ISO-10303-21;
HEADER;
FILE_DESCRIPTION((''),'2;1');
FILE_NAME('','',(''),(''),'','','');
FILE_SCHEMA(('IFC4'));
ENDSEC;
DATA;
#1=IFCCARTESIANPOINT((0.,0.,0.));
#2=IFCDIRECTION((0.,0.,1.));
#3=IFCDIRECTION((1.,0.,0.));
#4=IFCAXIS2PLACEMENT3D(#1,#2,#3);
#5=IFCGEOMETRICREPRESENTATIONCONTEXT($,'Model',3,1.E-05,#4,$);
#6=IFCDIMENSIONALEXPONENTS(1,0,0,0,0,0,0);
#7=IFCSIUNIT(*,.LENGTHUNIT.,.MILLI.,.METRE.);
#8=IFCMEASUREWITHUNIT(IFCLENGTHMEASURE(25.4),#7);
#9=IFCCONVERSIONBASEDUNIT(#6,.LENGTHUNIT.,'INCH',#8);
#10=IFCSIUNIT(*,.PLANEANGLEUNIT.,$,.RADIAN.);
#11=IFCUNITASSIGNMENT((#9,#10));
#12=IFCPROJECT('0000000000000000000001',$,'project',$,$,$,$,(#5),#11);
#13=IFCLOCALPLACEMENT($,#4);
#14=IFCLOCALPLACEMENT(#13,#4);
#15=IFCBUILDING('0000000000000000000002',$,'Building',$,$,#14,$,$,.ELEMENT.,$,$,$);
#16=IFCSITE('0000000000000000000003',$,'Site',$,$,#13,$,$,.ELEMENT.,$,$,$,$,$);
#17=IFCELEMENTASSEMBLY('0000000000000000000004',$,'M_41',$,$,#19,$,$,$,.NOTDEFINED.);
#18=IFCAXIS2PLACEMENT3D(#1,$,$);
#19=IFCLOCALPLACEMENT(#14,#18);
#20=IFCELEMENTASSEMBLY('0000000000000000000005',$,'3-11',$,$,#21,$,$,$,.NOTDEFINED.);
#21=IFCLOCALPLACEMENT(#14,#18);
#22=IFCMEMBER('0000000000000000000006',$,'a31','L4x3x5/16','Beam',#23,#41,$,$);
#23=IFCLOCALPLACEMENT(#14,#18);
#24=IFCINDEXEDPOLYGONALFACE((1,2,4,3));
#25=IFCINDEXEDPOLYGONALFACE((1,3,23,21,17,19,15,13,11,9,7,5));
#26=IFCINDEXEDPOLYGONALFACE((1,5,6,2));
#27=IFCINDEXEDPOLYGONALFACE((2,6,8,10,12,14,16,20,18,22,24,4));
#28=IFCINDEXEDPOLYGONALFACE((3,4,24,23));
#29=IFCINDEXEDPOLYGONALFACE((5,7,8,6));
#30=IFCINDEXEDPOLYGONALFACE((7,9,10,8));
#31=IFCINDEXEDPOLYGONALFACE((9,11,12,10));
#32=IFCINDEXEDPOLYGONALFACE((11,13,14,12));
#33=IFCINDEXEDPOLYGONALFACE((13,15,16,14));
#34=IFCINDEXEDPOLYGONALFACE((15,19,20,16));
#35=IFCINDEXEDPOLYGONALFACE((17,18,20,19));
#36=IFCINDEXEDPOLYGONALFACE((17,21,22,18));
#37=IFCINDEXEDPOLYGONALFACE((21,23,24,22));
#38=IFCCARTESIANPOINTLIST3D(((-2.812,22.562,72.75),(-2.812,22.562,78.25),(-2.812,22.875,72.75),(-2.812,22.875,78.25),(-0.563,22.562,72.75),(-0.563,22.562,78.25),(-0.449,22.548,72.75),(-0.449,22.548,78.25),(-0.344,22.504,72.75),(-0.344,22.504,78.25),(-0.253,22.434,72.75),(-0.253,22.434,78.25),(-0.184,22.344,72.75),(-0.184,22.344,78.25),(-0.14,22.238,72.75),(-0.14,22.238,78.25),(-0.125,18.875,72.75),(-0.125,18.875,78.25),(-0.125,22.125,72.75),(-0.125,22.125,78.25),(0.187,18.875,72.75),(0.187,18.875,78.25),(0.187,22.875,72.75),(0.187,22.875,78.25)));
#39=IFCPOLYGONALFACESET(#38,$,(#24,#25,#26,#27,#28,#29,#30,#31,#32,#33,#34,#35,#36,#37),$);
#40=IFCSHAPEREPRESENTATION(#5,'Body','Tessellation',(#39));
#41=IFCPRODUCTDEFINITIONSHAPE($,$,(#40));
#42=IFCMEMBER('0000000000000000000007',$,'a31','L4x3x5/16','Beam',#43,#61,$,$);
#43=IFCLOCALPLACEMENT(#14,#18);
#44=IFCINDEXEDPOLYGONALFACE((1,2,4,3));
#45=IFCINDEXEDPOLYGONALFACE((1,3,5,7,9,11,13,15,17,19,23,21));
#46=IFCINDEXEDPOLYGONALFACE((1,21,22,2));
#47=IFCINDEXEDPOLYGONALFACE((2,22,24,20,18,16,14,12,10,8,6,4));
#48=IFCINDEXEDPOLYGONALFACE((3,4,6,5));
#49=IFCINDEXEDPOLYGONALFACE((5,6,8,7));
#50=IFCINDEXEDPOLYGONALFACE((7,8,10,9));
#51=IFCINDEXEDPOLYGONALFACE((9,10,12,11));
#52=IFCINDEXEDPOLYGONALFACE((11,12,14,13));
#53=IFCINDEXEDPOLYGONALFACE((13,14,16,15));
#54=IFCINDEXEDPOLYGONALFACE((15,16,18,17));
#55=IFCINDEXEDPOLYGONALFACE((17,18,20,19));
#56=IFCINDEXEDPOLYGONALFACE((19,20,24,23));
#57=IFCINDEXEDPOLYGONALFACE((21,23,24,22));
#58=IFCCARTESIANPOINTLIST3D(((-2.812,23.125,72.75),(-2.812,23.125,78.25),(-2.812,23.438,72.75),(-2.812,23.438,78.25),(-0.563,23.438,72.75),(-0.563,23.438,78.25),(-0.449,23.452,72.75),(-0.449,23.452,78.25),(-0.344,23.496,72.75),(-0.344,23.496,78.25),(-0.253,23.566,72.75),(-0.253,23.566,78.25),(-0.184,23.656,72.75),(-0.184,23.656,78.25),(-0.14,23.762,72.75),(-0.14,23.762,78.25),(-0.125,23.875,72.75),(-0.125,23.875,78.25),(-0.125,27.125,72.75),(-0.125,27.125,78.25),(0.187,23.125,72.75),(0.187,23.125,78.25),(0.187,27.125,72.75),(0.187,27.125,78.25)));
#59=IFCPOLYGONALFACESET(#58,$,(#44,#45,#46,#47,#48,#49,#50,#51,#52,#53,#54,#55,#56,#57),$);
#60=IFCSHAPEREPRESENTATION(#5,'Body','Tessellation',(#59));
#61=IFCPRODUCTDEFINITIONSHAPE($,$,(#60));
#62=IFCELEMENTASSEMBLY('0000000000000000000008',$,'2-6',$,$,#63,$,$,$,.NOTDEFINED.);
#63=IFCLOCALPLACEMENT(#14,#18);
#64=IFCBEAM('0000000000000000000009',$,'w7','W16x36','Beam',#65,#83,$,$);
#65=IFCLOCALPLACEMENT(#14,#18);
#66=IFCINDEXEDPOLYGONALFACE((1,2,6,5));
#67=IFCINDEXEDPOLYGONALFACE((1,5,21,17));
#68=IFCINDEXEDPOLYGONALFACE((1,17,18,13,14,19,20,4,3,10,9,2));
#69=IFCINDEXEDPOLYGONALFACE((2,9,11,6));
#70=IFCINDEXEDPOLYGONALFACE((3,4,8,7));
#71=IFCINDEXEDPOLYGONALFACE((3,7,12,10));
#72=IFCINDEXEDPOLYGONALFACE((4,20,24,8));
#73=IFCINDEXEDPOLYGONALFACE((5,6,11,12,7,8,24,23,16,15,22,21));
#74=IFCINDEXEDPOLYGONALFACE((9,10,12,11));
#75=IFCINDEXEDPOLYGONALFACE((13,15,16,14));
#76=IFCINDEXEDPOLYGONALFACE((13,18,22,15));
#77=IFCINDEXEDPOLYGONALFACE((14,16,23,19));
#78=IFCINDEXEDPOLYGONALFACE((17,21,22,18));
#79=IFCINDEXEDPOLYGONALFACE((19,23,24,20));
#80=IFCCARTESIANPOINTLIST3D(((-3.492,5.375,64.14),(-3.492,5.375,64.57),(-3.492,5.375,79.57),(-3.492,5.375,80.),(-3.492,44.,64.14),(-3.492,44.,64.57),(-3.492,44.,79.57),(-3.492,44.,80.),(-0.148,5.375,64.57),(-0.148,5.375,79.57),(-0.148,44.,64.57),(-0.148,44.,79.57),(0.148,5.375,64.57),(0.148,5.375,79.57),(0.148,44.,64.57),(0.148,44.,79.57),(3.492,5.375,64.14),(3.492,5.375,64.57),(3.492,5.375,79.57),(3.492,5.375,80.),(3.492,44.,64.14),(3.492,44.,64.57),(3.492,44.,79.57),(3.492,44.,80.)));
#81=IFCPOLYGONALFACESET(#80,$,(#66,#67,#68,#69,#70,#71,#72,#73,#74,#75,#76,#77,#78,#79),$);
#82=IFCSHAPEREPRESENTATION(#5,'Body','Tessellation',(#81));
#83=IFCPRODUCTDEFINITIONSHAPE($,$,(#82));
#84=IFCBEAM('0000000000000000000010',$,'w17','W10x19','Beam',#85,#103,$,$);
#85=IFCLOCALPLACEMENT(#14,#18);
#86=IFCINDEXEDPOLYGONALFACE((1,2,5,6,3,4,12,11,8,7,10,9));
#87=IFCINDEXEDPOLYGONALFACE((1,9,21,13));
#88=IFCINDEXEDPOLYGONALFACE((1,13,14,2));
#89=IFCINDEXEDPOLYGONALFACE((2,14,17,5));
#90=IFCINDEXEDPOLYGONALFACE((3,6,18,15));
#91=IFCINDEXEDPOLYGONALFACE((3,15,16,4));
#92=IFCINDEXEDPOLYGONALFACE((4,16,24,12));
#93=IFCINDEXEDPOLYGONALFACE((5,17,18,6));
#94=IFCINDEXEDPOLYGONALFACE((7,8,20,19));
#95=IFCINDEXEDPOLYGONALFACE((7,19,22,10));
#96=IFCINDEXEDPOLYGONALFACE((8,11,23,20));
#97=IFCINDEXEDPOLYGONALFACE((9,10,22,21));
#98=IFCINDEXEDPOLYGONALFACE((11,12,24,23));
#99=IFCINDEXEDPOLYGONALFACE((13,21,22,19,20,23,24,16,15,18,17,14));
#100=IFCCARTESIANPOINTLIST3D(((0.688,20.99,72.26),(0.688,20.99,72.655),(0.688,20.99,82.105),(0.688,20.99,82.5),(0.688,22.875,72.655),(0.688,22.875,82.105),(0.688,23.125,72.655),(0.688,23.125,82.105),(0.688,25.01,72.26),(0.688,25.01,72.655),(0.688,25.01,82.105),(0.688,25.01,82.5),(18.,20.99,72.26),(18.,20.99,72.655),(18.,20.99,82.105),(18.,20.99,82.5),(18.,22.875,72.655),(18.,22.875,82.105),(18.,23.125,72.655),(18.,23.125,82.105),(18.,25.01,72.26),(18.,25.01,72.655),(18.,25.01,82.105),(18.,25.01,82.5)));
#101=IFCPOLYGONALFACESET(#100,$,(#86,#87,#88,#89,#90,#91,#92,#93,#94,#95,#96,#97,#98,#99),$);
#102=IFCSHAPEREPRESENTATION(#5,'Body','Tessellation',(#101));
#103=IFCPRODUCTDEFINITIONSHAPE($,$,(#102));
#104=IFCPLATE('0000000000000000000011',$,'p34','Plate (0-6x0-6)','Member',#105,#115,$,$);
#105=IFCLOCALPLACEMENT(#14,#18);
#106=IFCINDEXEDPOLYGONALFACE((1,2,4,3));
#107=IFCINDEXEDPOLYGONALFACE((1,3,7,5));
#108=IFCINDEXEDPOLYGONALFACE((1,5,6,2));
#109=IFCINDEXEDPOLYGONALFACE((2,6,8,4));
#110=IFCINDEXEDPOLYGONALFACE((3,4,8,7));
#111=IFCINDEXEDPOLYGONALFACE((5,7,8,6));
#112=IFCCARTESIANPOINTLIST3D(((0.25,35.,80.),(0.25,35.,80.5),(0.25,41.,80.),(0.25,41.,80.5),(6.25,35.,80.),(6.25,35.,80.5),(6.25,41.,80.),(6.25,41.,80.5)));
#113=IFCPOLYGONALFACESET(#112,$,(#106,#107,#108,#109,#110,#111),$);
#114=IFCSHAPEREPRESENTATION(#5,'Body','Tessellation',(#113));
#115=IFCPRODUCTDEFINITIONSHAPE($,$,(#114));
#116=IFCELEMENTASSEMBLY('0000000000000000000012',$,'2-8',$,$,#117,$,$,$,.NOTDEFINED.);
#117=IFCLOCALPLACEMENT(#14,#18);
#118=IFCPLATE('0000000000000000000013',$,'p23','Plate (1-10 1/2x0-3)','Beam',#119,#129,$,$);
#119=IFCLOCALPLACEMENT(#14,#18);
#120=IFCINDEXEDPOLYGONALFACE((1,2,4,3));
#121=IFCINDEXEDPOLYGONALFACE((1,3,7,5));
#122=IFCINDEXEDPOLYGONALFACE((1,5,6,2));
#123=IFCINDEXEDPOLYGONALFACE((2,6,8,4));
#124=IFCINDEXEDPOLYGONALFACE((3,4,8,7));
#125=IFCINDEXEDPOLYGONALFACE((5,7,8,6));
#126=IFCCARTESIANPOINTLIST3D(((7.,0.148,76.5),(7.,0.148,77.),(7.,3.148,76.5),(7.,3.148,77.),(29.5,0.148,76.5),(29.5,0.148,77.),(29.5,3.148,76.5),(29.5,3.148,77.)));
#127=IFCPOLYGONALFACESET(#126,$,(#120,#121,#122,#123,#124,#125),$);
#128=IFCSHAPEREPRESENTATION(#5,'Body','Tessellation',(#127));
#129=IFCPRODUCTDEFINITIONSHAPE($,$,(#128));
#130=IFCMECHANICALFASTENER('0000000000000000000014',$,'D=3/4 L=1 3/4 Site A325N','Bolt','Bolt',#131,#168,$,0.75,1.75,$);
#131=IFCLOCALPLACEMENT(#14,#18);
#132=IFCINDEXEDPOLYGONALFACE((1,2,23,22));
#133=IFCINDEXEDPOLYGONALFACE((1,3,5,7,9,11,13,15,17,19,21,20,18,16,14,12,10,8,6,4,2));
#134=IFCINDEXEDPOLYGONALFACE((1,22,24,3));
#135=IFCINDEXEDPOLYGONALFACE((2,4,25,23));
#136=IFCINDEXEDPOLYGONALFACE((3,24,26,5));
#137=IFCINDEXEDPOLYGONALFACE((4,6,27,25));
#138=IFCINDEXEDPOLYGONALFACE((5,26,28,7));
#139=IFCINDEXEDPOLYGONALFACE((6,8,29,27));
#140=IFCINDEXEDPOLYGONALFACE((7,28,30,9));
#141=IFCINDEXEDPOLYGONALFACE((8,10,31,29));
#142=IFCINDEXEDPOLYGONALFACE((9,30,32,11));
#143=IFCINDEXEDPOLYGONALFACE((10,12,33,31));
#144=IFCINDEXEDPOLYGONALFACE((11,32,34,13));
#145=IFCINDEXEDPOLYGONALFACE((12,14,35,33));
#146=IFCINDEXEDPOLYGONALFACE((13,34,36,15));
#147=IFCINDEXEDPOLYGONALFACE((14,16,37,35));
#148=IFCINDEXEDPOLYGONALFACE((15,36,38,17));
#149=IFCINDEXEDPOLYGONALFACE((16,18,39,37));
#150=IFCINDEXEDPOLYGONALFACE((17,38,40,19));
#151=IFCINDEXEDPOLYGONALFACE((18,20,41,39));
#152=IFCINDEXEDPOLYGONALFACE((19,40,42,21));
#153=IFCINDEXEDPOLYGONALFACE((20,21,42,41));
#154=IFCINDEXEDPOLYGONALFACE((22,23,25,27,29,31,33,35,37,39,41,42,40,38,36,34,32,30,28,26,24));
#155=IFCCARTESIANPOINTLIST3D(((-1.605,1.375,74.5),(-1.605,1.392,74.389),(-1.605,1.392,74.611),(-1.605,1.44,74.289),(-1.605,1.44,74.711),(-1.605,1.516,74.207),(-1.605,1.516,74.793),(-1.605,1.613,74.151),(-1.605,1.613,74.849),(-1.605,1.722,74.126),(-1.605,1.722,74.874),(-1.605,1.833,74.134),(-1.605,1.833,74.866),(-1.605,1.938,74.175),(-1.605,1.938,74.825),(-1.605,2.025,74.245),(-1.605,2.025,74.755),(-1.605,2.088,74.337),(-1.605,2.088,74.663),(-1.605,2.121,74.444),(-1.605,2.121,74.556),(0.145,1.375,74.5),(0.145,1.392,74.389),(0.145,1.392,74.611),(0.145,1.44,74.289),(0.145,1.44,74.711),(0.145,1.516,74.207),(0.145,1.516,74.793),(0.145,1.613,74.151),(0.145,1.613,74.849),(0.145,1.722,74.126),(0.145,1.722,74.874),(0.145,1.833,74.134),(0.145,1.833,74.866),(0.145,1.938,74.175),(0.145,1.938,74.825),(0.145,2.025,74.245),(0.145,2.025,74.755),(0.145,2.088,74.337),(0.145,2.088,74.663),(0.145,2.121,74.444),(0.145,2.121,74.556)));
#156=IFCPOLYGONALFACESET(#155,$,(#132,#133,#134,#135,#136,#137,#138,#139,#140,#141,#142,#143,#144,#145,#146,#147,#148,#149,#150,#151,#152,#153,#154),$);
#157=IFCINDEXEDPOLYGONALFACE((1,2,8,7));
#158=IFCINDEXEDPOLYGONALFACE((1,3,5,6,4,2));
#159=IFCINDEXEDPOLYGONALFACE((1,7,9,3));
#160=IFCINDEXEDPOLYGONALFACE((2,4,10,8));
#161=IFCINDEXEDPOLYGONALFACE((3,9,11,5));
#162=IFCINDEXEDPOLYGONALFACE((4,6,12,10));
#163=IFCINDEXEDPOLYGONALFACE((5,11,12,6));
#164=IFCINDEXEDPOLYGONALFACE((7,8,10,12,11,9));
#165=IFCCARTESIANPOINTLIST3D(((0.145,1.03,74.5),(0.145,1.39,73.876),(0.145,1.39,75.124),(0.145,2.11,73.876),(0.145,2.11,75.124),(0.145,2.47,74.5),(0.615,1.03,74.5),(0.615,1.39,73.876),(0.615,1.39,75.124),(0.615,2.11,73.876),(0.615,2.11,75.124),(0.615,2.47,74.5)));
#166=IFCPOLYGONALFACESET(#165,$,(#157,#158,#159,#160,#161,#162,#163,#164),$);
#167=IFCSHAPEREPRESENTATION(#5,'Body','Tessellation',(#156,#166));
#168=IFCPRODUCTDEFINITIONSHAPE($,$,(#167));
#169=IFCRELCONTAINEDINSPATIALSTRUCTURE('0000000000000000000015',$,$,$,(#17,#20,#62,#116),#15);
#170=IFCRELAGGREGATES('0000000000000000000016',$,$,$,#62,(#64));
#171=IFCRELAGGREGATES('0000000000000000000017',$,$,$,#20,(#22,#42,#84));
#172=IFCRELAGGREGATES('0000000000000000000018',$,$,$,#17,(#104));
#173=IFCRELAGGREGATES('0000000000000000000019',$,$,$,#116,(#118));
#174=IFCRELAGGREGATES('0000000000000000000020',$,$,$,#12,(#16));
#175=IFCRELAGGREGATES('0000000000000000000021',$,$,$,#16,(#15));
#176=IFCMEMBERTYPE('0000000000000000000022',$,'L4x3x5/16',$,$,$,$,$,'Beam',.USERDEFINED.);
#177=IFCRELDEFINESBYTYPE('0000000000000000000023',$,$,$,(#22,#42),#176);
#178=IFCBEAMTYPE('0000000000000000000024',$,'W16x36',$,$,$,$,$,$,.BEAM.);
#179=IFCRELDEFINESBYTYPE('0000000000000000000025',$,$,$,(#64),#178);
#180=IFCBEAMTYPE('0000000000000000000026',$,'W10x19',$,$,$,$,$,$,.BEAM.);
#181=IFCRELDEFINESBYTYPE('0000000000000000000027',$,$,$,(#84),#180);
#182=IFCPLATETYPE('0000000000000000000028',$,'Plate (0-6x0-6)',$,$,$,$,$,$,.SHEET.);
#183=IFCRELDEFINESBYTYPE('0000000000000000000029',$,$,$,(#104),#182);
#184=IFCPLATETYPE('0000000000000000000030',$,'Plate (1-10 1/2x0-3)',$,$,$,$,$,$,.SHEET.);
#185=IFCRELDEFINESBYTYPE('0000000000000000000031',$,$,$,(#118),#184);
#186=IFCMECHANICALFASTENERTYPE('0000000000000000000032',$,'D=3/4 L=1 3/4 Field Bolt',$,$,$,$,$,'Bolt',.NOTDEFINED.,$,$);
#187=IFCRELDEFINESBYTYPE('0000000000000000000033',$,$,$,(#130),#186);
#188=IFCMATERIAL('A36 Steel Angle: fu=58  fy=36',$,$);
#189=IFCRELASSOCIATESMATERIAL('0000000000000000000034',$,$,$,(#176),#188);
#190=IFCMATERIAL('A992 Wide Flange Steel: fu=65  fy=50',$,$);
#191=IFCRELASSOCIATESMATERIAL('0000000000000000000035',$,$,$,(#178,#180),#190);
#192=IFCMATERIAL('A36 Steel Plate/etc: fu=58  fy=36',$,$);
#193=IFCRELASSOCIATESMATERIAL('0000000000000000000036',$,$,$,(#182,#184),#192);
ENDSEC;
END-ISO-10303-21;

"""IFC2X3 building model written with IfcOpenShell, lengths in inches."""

from ifc_helpers import new_model, entity, si_unit, converted_unit, frame, frame_2d, origin_with_axes, origin_2d_with_axis, place, context, project, spatial, polyline, circle, i_section, l_section, outline, transform_2d, derived_profile, extrude, source, transform, mapped, material, type_object, type_shapes, element, aggregate, save


model = new_model("IFC2X3")

# Units and contexts
model_context = context("Model", 3, precision=1e-05, world=origin_with_axes())
ifc_project = project(units=[converted_unit("LENGTHUNIT", "INCH", entity("IfcLengthMeasure", 25.4), si_unit("LENGTHUNIT", "METRE", prefix="MILLI"), dimensions=[1, 0, 0, 0, 0, 0, 0]), si_unit("PLANEANGLEUNIT", "RADIAN")], contexts=[model_context])

# Site, building
site_placement = place(None, origin_with_axes())
site = spatial("IfcSite", under=ifc_project, at=site_placement, Name="Site", CompositionType="ELEMENT")
building_placement = place(site_placement, origin_with_axes())
building = spatial("IfcBuilding", under=site, at=building_placement, Name="Building", CompositionType="ELEMENT")

# Element assembly
ifc_material_1 = material(Name="A36 Steel Angle: fu=58  fy=36")
assembly_1_placement = place(building_placement, frame((0.0, 38.0, 82.5), z_axis=(0.0, 0.0, -1.0), x_axis=(1.0, 0.0, 0.0)))
assembly_1 = element("IfcElementAssembly", 1, at=assembly_1_placement, inside=building, Name="M_41", PredefinedType="NOTDEFINED")

# Element assembly, members
assembly_2_placement = place(building_placement, frame((0.0, 23.0, 82.5), z_axis=(0.0, 0.0, 1.0), x_axis=(1.0, 0.0, 0.0)))
assembly_2 = element("IfcElementAssembly", 2, at=assembly_2_placement, inside=building, Name="3-11", PredefinedType="NOTDEFINED")
member_type_1 = type_object("IfcMemberType", Name="L4x3x5/16", ElementType="Beam", PredefinedType="USERDEFINED", material=ifc_material_1)
shared_shape_1 = source(origin_with_axes(), model_context, "Body", "SweptSolid", [
    extrude(derived_profile(l_section(Depth=4.0, Width=3.0, Thickness=0.312, FilletRadius=0.438, at=frame_2d((1.5, 2.0), x_axis=(1.0, 0.0))), transform_2d((0.0, 0.0), x_axis=(-1.0, 0.0), y_axis=(0.0, 1.0))), frame((0.0, 0.0, 0.0), z_axis=(1.0, 0.0, 0.0), x_axis=(0.0, 1.0, 0.0)), (0.0, 0.0, 1.0), 5.5),
])
type_shapes(member_type_1, [shared_shape_1])
member_1_placement = place(assembly_2_placement, frame((0.188, -0.125, -9.75), z_axis=(0.0, -1.0, 0.0), x_axis=(0.0, 0.0, 1.0)))
member_1 = element("IfcMember", 3, at=member_1_placement, type_object=member_type_1, Name="a31", Description="L4x3x5/16", ObjectType="Beam", context=model_context, shape_type="MappedRepresentation", body=[
    mapped(shared_shape_1, transform((0.0, 0.0, 0.0), scale=1.0)),
])
member_2_placement = place(assembly_2_placement, frame((0.188, 0.125, -4.25), z_axis=(0.0, 1.0, 0.0), x_axis=(0.0, 0.0, -1.0)))
member_2 = element("IfcMember", 4, at=member_2_placement, type_object=member_type_1, Name="a31", Description="L4x3x5/16", ObjectType="Beam", context=model_context, shape_type="MappedRepresentation", body=[
    mapped(shared_shape_1, transform((0.0, 0.0, 0.0), scale=1.0)),
])

# Element assembly, beam
assembly_3_placement = place(building_placement, frame((0.0, 0.0, 80.0), z_axis=(0.0, 0.0, 1.0), x_axis=(0.0, 1.0, 0.0)))
assembly_3 = element("IfcElementAssembly", 5, at=assembly_3_placement, inside=building, Name="2-6", PredefinedType="NOTDEFINED")
ifc_material_2 = material(Name="A992 Wide Flange Steel: fu=65  fy=50")
beam_type_1 = type_object("IfcBeamType", Name="W16x36", PredefinedType="BEAM", material=ifc_material_2)
shared_shape_2 = source(origin_with_axes(), model_context, "Body", "SweptSolid", [
    extrude(i_section(OverallWidth=6.985, OverallDepth=15.86, WebThickness=0.295, FlangeThickness=0.43, at=frame_2d((0.0, -7.93), x_axis=(1.0, 0.0))), frame((0.0, 0.0, 0.0), z_axis=(1.0, 0.0, 0.0), x_axis=(0.0, 1.0, 0.0)), (0.0, 0.0, 1.0), 38.625),
])
type_shapes(beam_type_1, [shared_shape_2])
beam_1_placement = place(assembly_3_placement, frame((5.375, 0.0, 0.0), z_axis=(0.0, 0.0, 1.0), x_axis=(1.0, 0.0, 0.0)))
beam_1 = element("IfcBeam", 6, at=beam_1_placement, type_object=beam_type_1, Name="w7", Description="W16x36", ObjectType="Beam", context=model_context, shape_type="MappedRepresentation", body=[
    mapped(shared_shape_2, transform((0.0, 0.0, 0.0), scale=1.0)),
])
aggregate(assembly_3, [beam_1])

# Beam
beam_type_2 = type_object("IfcBeamType", Name="W10x19", PredefinedType="BEAM", material=ifc_material_2)
shared_shape_3 = source(origin_with_axes(), model_context, "Body", "SweptSolid", [
    extrude(i_section(OverallWidth=4.02, OverallDepth=10.24, WebThickness=0.25, FlangeThickness=0.395, at=frame_2d((0.0, -5.12), x_axis=(1.0, 0.0))), frame((0.0, 0.0, 0.0), z_axis=(1.0, 0.0, 0.0), x_axis=(0.0, 1.0, 0.0)), (0.0, 0.0, 1.0), 17.312),
])
type_shapes(beam_type_2, [shared_shape_3])
beam_2_placement = place(assembly_2_placement, frame((0.688, 0.0, 0.0), z_axis=(0.0, 0.0, 1.0), x_axis=(1.0, 0.0, 0.0)))
beam_2 = element("IfcBeam", 7, at=beam_2_placement, type_object=beam_type_2, Name="w17", Description="W10x19", ObjectType="Beam", context=model_context, shape_type="MappedRepresentation", body=[
    mapped(shared_shape_3, transform((0.0, 0.0, 0.0), scale=1.0)),
])
aggregate(assembly_2, [member_1, member_2, beam_2])

# Plate
ifc_material_3 = material(Name="A36 Steel Plate/etc: fu=58  fy=36")
plate_type_1 = type_object("IfcPlateType", Name="Plate (0-6x0-6)", PredefinedType="SHEET", material=ifc_material_3)
shared_shape_4 = source(origin_with_axes(), model_context, "Body", "SweptSolid", [
    extrude(outline(polyline([(0.0, -6.0), (-6.0, -6.0), (-6.0, 0.0), (0.0, 0.0), (0.0, -6.0)])), frame((-0.25, 0.0, 0.0), z_axis=(1.0, 0.0, 0.0), x_axis=(0.0, 1.0, 0.0)), (0.0, 0.0, 1.0), 0.5),
])
type_shapes(plate_type_1, [shared_shape_4])
plate_1_placement = place(assembly_1_placement, frame((6.25, -3.0, 2.25), z_axis=(0.0, -1.0, 0.0), x_axis=(0.0, 0.0, -1.0)))
plate_1 = element("IfcPlate", 8, at=plate_1_placement, type_object=plate_type_1, Name="p34", Description="Plate (0-6x0-6)", ObjectType="Member", context=model_context, shape_type="MappedRepresentation", body=[
    mapped(shared_shape_4, transform((0.0, 0.0, 0.0), scale=1.0)),
])
aggregate(assembly_1, [plate_1])

# Element assembly, plate
assembly_4_placement = place(building_placement, frame((0.0, 0.0, 80.0), z_axis=(0.0, 0.0, 1.0), x_axis=(1.0, 0.0, 0.0)))
assembly_4 = element("IfcElementAssembly", 9, at=assembly_4_placement, inside=building, Name="2-8", PredefinedType="NOTDEFINED")
plate_type_2 = type_object("IfcPlateType", Name="Plate (1-10 1/2x0-3)", PredefinedType="SHEET", material=ifc_material_3)
shared_shape_5 = source(origin_with_axes(), model_context, "Body", "SweptSolid", [
    extrude(outline(polyline([(0.0, -22.5), (-3.0, -22.5), (-3.0, 0.0), (0.0, 0.0), (0.0, -22.5)])), frame((-0.25, 0.0, 0.0), z_axis=(1.0, 0.0, 0.0), x_axis=(0.0, 1.0, 0.0)), (0.0, 0.0, 1.0), 0.5),
])
type_shapes(plate_type_2, [shared_shape_5])
plate_2_placement = place(assembly_4_placement, frame((29.5, 0.148, -3.25), z_axis=(1.0, 0.0, 0.0), x_axis=(0.0, 0.0, 1.0)))
plate_2 = element("IfcPlate", 10, at=plate_2_placement, type_object=plate_type_2, Name="p23", Description="Plate (1-10 1/2x0-3)", ObjectType="Beam", context=model_context, shape_type="MappedRepresentation", body=[
    mapped(shared_shape_5, transform((0.0, 0.0, 0.0), scale=1.0)),
])
aggregate(assembly_4, [plate_2])

# Mechanical fastener
mechanical_fastener_type_1 = type_object("IfcMechanicalFastenerType", Name="D=3/4 L=1 3/4 Field Bolt", ElementType="Bolt")
shared_shape_6 = source(origin_with_axes(), model_context, "Body", "SweptSolid", [
    extrude(circle(Radius=0.375, at=origin_2d_with_axis()), frame((0.0, 0.0, 0.0), z_axis=(1.0, 0.0, 0.0), x_axis=(0.0, 1.0, 0.0)), (0.0, 0.0, 1.0), 1.75),
    extrude(outline(polyline([(-0.72, 0.0), (-0.36, 0.624), (0.36, 0.624), (0.72, 0.0), (0.36, -0.624), (-0.36, -0.624), (-0.72, 0.0)])), frame((0.0, 0.0, 0.0), z_axis=(1.0, 0.0, 0.0), x_axis=(0.0, 1.0, 0.0)), (0.0, 0.0, -1.0), 0.47),
])
type_shapes(mechanical_fastener_type_1, [shared_shape_6])
placement_1 = place(building_placement, frame((0.0, 0.0, 80.0), z_axis=(0.0, 0.0, 1.0), x_axis=(-1.0, 0.0, 0.0)))
placement_2 = place(placement_1, frame((-0.145, -1.75, -11.5), z_axis=(0.0, 0.0, 1.0), x_axis=(1.0, 0.0, 0.0)))
for number, where, z_axis, x_axis, name in (
    (11, (0.0, 0.0, 6.0), (0.0, 0.0, 1.0), (1.0, 0.0, 0.0), "D=3/4 L=1 3/4 Site A325N"),
):
    element("IfcMechanicalFastener", number, at=place(placement_2, frame(where, z_axis=z_axis, x_axis=x_axis)), type_object=mechanical_fastener_type_1, Name=name, Description="Bolt", ObjectType="Bolt", NominalDiameter=0.75, NominalLength=1.75, context=model_context, shape_type="MappedRepresentation", body=[
        mapped(shared_shape_6, transform((0.0, 0.0, 0.0), scale=1.0)),
    ])

save(model, "model.ifc")
